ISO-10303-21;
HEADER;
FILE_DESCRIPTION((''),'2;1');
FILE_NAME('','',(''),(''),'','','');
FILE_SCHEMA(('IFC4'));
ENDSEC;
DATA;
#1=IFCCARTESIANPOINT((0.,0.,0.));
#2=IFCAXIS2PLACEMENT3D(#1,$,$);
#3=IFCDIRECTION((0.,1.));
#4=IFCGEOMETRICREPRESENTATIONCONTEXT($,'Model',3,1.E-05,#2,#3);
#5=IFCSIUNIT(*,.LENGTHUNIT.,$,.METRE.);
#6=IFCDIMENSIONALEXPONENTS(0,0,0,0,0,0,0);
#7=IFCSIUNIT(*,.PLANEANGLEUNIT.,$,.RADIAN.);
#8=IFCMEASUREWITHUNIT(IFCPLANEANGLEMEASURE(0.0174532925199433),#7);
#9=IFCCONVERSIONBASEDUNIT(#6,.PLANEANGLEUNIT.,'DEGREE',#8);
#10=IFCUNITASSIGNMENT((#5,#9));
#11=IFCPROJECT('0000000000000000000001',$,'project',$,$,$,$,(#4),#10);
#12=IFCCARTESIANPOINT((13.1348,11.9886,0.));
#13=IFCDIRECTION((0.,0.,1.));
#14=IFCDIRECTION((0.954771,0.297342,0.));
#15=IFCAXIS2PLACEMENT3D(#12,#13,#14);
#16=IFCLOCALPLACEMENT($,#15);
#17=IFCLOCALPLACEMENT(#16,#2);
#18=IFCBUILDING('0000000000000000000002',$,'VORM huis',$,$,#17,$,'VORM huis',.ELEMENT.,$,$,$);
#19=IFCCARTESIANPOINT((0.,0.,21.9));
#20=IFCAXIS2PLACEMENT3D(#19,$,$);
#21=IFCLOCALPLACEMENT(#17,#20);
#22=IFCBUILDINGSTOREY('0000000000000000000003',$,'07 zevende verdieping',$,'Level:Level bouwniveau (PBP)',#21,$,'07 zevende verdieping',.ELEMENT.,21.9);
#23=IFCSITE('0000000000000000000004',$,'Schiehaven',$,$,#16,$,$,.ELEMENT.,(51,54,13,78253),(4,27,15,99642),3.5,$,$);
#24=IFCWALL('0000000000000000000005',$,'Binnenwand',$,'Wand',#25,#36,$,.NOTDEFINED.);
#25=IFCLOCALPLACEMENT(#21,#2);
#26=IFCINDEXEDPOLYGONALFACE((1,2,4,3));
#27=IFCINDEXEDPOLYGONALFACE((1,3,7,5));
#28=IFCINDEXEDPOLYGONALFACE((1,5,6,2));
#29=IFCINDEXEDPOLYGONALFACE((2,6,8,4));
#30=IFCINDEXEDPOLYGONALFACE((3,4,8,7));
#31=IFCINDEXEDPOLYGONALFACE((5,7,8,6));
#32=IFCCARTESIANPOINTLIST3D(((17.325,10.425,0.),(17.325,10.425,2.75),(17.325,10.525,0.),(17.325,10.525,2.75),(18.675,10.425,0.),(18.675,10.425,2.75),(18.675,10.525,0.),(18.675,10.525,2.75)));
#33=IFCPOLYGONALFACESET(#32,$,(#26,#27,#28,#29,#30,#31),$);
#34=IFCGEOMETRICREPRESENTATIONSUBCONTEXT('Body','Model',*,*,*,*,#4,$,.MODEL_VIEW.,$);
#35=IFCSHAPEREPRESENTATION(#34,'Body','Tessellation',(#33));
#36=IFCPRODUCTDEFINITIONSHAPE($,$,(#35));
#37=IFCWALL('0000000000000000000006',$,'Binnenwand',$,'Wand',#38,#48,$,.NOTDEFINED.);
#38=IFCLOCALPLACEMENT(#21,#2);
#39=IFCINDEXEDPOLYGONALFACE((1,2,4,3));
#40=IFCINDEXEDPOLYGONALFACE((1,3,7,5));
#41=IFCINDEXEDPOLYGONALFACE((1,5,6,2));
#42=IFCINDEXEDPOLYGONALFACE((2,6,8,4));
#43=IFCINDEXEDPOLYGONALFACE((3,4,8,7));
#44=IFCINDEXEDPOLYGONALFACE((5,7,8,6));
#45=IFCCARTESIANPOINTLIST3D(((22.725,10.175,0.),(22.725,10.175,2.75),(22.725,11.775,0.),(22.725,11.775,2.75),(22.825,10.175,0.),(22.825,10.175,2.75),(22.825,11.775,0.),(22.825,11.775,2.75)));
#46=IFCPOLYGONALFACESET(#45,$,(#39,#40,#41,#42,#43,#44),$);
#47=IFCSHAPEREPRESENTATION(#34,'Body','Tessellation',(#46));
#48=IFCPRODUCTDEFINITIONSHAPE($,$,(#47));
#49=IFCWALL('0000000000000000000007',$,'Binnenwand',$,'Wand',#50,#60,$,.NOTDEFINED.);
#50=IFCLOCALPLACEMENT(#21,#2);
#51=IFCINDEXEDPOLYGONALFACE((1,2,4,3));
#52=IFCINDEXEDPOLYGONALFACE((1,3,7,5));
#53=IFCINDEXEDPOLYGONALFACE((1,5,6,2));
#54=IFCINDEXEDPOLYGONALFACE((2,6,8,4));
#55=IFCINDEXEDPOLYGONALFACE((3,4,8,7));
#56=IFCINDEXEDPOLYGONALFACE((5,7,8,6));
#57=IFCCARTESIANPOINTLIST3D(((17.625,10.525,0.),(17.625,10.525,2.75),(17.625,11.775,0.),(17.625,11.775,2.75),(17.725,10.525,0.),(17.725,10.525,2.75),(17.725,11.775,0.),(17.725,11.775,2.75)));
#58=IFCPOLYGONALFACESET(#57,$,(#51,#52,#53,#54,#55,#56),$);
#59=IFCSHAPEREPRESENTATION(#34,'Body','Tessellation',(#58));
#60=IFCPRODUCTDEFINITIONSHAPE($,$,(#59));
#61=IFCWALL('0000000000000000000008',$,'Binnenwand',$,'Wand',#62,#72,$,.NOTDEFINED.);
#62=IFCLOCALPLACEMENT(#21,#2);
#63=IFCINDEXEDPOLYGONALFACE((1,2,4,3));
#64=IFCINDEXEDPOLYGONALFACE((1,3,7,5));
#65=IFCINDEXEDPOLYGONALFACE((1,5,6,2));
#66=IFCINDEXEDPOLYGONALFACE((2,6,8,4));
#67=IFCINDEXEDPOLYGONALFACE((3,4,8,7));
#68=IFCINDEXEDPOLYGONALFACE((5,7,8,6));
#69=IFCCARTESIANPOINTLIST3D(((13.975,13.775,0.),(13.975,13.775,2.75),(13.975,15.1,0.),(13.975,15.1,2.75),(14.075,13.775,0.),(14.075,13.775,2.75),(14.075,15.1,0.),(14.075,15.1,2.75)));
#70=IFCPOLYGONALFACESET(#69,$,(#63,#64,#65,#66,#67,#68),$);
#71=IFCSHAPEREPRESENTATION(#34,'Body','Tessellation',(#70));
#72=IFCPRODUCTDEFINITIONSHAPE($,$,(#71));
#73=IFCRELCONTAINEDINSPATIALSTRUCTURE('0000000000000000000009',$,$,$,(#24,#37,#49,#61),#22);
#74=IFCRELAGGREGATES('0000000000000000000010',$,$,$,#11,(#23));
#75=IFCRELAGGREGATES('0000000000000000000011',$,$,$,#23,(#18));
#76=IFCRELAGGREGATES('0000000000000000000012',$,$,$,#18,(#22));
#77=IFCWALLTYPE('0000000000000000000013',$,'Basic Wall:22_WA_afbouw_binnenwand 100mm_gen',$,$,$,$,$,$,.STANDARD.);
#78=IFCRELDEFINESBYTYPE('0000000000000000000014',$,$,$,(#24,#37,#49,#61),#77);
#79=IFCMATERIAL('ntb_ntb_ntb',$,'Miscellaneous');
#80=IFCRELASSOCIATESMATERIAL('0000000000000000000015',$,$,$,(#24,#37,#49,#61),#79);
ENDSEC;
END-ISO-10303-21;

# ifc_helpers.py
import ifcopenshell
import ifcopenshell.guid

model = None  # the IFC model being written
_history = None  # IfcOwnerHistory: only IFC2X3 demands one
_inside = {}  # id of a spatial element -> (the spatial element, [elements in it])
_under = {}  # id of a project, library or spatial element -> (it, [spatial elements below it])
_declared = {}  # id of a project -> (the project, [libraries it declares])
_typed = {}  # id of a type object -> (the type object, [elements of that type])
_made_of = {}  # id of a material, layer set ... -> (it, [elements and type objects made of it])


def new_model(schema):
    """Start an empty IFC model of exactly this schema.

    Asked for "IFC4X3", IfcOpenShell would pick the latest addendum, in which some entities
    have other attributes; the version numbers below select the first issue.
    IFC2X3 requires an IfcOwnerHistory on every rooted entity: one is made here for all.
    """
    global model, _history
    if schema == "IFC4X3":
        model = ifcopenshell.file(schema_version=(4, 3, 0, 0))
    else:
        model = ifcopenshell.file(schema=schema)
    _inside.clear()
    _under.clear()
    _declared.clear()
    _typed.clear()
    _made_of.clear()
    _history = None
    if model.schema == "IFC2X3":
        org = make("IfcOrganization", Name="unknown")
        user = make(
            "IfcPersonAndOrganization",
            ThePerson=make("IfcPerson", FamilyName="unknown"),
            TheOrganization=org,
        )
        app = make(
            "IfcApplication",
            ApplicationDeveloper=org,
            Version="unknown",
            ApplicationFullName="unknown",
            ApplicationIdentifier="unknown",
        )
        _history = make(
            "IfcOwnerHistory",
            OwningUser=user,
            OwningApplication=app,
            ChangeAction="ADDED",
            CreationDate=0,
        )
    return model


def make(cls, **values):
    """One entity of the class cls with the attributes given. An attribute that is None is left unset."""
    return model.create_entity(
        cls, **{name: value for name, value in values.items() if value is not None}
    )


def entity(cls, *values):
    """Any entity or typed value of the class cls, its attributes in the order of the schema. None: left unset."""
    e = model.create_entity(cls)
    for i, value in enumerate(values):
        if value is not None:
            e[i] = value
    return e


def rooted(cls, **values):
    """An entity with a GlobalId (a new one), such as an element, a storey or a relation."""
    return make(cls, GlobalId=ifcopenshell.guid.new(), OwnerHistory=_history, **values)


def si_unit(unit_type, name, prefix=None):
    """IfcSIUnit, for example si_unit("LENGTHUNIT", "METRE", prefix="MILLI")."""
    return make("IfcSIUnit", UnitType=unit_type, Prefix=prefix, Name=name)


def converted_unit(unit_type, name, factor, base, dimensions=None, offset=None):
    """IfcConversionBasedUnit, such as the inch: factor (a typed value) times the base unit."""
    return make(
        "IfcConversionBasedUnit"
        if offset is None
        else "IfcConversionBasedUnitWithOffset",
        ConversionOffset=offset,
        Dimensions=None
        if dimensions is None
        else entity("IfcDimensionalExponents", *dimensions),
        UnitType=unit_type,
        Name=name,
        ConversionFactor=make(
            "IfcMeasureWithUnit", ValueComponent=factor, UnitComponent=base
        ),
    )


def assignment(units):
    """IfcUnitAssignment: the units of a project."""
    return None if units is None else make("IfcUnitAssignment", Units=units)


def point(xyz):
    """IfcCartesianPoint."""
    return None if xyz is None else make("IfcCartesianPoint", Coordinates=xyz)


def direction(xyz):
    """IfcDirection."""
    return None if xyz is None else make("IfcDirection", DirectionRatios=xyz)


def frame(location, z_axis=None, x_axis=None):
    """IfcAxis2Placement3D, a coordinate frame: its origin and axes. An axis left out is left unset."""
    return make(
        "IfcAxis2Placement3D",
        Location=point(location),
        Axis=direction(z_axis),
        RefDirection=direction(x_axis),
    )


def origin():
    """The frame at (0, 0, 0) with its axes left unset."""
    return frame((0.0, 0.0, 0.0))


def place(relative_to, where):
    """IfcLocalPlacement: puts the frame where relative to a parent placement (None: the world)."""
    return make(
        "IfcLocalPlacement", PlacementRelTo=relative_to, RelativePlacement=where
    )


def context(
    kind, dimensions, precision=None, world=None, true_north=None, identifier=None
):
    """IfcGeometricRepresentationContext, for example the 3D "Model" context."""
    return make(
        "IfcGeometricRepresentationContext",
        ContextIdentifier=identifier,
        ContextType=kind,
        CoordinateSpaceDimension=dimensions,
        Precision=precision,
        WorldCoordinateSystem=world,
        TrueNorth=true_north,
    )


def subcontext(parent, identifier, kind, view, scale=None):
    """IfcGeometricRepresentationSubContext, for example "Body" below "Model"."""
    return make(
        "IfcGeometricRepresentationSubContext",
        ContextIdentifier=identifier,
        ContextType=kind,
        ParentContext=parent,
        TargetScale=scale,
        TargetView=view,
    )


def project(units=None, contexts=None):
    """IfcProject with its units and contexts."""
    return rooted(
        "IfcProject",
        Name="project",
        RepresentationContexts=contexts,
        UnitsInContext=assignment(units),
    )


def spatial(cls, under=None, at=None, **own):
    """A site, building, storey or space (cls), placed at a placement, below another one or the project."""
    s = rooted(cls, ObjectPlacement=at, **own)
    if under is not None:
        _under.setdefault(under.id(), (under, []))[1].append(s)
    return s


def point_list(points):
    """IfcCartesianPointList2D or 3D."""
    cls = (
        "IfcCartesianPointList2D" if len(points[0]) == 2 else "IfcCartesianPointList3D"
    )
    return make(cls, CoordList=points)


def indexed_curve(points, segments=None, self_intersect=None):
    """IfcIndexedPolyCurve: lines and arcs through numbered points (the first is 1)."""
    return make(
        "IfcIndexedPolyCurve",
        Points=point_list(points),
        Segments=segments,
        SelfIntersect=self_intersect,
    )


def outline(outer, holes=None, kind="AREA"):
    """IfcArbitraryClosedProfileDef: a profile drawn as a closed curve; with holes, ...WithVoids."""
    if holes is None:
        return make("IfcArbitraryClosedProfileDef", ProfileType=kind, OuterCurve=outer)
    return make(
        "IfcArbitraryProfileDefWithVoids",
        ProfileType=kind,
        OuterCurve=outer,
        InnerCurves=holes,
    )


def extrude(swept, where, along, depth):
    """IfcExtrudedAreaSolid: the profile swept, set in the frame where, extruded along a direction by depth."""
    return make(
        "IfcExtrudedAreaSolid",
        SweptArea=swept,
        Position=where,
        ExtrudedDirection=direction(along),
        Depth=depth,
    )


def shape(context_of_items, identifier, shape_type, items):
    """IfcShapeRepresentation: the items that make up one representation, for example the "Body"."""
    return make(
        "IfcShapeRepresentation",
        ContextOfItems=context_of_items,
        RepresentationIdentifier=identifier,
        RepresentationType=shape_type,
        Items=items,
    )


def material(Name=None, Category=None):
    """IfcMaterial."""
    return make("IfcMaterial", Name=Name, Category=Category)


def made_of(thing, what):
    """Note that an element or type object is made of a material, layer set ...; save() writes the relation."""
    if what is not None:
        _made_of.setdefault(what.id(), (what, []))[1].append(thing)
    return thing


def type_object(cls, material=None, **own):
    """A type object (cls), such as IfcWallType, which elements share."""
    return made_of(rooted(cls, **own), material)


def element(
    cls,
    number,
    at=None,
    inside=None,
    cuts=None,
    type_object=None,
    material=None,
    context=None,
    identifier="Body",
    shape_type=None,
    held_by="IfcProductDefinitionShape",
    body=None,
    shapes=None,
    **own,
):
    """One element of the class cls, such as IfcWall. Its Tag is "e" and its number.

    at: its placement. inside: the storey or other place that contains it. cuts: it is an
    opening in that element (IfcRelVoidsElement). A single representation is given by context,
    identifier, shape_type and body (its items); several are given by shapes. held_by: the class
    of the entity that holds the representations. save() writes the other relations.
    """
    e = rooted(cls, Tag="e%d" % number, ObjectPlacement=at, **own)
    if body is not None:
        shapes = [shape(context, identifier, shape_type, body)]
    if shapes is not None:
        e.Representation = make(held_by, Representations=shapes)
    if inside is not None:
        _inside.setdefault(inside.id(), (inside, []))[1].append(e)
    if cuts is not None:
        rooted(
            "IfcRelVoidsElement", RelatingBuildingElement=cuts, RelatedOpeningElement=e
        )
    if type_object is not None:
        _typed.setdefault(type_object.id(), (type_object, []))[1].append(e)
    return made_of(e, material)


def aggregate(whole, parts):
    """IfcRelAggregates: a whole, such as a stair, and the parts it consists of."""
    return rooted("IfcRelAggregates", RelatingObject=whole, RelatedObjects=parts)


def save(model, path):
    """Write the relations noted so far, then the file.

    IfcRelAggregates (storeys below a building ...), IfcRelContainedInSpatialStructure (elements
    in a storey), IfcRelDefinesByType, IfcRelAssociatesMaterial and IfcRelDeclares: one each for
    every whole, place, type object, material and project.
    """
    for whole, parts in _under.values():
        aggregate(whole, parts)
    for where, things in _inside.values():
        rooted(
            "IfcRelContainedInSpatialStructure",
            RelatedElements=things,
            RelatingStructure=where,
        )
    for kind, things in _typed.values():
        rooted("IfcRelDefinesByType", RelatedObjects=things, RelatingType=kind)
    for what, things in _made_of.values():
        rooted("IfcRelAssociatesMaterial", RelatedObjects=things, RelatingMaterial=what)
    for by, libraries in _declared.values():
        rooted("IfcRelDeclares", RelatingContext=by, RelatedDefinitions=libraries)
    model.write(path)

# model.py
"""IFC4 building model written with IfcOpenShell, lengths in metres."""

from ifc_helpers import new_model, entity, si_unit, converted_unit, direction, frame, origin, place, context, subcontext, project, spatial, indexed_curve, outline, extrude, material, type_object, element, save


model = new_model("IFC4")

# Units and contexts
model_context = context("Model", 3, precision=1e-05, world=origin(), true_north=direction((0.0, 1.0)))
body_context = subcontext(model_context, "Body", "Model", "MODEL_VIEW")
ifc_project = project(units=[si_unit("LENGTHUNIT", "METRE"), converted_unit("PLANEANGLEUNIT", "DEGREE", entity("IfcPlaneAngleMeasure", 0.0174532925199433), si_unit("PLANEANGLEUNIT", "RADIAN"), dimensions=[0, 0, 0, 0, 0, 0, 0])], contexts=[model_context])

# Site, building, storey
site_placement = place(None, frame((13.1348, 11.9886, 0.0), z_axis=(0.0, 0.0, 1.0), x_axis=(0.954771, 0.297342, 0.0)))
site = spatial("IfcSite", under=ifc_project, at=site_placement, Name="Schiehaven", CompositionType="ELEMENT", RefLatitude=(51, 54, 13, 78253), RefLongitude=(4, 27, 15, 99642), RefElevation=3.5)
building_placement = place(site_placement, origin())
building = spatial("IfcBuilding", under=site, at=building_placement, Name="VORM huis", LongName="VORM huis", CompositionType="ELEMENT")
storey_placement = place(building_placement, frame((0.0, 0.0, 21.9)))
storey = spatial("IfcBuildingStorey", under=building, at=storey_placement, Name="07 zevende verdieping", ObjectType="Level:Level bouwniveau (PBP)", LongName="07 zevende verdieping", CompositionType="ELEMENT", Elevation=21.9)

# Walls
ifc_material_1 = material(Name="ntb_ntb_ntb", Category="Miscellaneous")
wall_type_1 = type_object("IfcWallType", Name="Basic Wall:22_WA_afbouw_binnenwand 100mm_gen", PredefinedType="STANDARD")
wall_1_placement = place(storey_placement, frame((17.325, 10.475, 0.0)))
element("IfcWall", 1, at=wall_1_placement, inside=storey, type_object=wall_type_1, material=ifc_material_1, Name="Binnenwand", ObjectType="Wand", PredefinedType="NOTDEFINED", context=body_context, shape_type="SweptSolid", body=[
    extrude(outline(indexed_curve([(1.35, 0.05), (0.0, 0.05), (0.0, -0.05), (1.35, -0.05), (1.35, 0.05)], self_intersect=False)), origin(), (0.0, 0.0, 1.0), 2.75),
])
wall_2_placement = place(storey_placement, frame((22.775, 10.175, 0.0), z_axis=(0.0, 0.0, 1.0), x_axis=(0.0, 1.0, 0.0)))
element("IfcWall", 2, at=wall_2_placement, inside=storey, type_object=wall_type_1, material=ifc_material_1, Name="Binnenwand", ObjectType="Wand", PredefinedType="NOTDEFINED", context=body_context, shape_type="SweptSolid", body=[
    extrude(outline(indexed_curve([(1.6, 0.05), (0.0, 0.05), (0.0, -0.05), (1.6, -0.05), (1.6, 0.05)], self_intersect=False)), origin(), (0.0, 0.0, 1.0), 2.75),
])
wall_3_placement = place(storey_placement, frame((17.675, 11.775, 0.0), z_axis=(0.0, 0.0, 1.0), x_axis=(0.0, -1.0, 0.0)))
element("IfcWall", 3, at=wall_3_placement, inside=storey, type_object=wall_type_1, material=ifc_material_1, Name="Binnenwand", ObjectType="Wand", PredefinedType="NOTDEFINED", context=body_context, shape_type="SweptSolid", body=[
    extrude(outline(indexed_curve([(1.25, 0.05), (0.0, 0.05), (0.0, -0.05), (1.25, -0.05), (1.25, 0.05)], self_intersect=False)), origin(), (0.0, 0.0, 1.0), 2.75),
])
wall_4_placement = place(storey_placement, frame((14.025, 13.775, 0.0), z_axis=(0.0, 0.0, 1.0), x_axis=(0.0, 1.0, 0.0)))
element("IfcWall", 4, at=wall_4_placement, inside=storey, type_object=wall_type_1, material=ifc_material_1, Name="Binnenwand", ObjectType="Wand", PredefinedType="NOTDEFINED", context=body_context, shape_type="SweptSolid", body=[
    extrude(outline(indexed_curve([(1.325, 0.05), (0.0, 0.05), (0.0, -0.05), (1.325, -0.05), (1.325, 0.05)], self_intersect=False)), origin(), (0.0, 0.0, 1.0), 2.75),
])

save(model, "model.ifc")
